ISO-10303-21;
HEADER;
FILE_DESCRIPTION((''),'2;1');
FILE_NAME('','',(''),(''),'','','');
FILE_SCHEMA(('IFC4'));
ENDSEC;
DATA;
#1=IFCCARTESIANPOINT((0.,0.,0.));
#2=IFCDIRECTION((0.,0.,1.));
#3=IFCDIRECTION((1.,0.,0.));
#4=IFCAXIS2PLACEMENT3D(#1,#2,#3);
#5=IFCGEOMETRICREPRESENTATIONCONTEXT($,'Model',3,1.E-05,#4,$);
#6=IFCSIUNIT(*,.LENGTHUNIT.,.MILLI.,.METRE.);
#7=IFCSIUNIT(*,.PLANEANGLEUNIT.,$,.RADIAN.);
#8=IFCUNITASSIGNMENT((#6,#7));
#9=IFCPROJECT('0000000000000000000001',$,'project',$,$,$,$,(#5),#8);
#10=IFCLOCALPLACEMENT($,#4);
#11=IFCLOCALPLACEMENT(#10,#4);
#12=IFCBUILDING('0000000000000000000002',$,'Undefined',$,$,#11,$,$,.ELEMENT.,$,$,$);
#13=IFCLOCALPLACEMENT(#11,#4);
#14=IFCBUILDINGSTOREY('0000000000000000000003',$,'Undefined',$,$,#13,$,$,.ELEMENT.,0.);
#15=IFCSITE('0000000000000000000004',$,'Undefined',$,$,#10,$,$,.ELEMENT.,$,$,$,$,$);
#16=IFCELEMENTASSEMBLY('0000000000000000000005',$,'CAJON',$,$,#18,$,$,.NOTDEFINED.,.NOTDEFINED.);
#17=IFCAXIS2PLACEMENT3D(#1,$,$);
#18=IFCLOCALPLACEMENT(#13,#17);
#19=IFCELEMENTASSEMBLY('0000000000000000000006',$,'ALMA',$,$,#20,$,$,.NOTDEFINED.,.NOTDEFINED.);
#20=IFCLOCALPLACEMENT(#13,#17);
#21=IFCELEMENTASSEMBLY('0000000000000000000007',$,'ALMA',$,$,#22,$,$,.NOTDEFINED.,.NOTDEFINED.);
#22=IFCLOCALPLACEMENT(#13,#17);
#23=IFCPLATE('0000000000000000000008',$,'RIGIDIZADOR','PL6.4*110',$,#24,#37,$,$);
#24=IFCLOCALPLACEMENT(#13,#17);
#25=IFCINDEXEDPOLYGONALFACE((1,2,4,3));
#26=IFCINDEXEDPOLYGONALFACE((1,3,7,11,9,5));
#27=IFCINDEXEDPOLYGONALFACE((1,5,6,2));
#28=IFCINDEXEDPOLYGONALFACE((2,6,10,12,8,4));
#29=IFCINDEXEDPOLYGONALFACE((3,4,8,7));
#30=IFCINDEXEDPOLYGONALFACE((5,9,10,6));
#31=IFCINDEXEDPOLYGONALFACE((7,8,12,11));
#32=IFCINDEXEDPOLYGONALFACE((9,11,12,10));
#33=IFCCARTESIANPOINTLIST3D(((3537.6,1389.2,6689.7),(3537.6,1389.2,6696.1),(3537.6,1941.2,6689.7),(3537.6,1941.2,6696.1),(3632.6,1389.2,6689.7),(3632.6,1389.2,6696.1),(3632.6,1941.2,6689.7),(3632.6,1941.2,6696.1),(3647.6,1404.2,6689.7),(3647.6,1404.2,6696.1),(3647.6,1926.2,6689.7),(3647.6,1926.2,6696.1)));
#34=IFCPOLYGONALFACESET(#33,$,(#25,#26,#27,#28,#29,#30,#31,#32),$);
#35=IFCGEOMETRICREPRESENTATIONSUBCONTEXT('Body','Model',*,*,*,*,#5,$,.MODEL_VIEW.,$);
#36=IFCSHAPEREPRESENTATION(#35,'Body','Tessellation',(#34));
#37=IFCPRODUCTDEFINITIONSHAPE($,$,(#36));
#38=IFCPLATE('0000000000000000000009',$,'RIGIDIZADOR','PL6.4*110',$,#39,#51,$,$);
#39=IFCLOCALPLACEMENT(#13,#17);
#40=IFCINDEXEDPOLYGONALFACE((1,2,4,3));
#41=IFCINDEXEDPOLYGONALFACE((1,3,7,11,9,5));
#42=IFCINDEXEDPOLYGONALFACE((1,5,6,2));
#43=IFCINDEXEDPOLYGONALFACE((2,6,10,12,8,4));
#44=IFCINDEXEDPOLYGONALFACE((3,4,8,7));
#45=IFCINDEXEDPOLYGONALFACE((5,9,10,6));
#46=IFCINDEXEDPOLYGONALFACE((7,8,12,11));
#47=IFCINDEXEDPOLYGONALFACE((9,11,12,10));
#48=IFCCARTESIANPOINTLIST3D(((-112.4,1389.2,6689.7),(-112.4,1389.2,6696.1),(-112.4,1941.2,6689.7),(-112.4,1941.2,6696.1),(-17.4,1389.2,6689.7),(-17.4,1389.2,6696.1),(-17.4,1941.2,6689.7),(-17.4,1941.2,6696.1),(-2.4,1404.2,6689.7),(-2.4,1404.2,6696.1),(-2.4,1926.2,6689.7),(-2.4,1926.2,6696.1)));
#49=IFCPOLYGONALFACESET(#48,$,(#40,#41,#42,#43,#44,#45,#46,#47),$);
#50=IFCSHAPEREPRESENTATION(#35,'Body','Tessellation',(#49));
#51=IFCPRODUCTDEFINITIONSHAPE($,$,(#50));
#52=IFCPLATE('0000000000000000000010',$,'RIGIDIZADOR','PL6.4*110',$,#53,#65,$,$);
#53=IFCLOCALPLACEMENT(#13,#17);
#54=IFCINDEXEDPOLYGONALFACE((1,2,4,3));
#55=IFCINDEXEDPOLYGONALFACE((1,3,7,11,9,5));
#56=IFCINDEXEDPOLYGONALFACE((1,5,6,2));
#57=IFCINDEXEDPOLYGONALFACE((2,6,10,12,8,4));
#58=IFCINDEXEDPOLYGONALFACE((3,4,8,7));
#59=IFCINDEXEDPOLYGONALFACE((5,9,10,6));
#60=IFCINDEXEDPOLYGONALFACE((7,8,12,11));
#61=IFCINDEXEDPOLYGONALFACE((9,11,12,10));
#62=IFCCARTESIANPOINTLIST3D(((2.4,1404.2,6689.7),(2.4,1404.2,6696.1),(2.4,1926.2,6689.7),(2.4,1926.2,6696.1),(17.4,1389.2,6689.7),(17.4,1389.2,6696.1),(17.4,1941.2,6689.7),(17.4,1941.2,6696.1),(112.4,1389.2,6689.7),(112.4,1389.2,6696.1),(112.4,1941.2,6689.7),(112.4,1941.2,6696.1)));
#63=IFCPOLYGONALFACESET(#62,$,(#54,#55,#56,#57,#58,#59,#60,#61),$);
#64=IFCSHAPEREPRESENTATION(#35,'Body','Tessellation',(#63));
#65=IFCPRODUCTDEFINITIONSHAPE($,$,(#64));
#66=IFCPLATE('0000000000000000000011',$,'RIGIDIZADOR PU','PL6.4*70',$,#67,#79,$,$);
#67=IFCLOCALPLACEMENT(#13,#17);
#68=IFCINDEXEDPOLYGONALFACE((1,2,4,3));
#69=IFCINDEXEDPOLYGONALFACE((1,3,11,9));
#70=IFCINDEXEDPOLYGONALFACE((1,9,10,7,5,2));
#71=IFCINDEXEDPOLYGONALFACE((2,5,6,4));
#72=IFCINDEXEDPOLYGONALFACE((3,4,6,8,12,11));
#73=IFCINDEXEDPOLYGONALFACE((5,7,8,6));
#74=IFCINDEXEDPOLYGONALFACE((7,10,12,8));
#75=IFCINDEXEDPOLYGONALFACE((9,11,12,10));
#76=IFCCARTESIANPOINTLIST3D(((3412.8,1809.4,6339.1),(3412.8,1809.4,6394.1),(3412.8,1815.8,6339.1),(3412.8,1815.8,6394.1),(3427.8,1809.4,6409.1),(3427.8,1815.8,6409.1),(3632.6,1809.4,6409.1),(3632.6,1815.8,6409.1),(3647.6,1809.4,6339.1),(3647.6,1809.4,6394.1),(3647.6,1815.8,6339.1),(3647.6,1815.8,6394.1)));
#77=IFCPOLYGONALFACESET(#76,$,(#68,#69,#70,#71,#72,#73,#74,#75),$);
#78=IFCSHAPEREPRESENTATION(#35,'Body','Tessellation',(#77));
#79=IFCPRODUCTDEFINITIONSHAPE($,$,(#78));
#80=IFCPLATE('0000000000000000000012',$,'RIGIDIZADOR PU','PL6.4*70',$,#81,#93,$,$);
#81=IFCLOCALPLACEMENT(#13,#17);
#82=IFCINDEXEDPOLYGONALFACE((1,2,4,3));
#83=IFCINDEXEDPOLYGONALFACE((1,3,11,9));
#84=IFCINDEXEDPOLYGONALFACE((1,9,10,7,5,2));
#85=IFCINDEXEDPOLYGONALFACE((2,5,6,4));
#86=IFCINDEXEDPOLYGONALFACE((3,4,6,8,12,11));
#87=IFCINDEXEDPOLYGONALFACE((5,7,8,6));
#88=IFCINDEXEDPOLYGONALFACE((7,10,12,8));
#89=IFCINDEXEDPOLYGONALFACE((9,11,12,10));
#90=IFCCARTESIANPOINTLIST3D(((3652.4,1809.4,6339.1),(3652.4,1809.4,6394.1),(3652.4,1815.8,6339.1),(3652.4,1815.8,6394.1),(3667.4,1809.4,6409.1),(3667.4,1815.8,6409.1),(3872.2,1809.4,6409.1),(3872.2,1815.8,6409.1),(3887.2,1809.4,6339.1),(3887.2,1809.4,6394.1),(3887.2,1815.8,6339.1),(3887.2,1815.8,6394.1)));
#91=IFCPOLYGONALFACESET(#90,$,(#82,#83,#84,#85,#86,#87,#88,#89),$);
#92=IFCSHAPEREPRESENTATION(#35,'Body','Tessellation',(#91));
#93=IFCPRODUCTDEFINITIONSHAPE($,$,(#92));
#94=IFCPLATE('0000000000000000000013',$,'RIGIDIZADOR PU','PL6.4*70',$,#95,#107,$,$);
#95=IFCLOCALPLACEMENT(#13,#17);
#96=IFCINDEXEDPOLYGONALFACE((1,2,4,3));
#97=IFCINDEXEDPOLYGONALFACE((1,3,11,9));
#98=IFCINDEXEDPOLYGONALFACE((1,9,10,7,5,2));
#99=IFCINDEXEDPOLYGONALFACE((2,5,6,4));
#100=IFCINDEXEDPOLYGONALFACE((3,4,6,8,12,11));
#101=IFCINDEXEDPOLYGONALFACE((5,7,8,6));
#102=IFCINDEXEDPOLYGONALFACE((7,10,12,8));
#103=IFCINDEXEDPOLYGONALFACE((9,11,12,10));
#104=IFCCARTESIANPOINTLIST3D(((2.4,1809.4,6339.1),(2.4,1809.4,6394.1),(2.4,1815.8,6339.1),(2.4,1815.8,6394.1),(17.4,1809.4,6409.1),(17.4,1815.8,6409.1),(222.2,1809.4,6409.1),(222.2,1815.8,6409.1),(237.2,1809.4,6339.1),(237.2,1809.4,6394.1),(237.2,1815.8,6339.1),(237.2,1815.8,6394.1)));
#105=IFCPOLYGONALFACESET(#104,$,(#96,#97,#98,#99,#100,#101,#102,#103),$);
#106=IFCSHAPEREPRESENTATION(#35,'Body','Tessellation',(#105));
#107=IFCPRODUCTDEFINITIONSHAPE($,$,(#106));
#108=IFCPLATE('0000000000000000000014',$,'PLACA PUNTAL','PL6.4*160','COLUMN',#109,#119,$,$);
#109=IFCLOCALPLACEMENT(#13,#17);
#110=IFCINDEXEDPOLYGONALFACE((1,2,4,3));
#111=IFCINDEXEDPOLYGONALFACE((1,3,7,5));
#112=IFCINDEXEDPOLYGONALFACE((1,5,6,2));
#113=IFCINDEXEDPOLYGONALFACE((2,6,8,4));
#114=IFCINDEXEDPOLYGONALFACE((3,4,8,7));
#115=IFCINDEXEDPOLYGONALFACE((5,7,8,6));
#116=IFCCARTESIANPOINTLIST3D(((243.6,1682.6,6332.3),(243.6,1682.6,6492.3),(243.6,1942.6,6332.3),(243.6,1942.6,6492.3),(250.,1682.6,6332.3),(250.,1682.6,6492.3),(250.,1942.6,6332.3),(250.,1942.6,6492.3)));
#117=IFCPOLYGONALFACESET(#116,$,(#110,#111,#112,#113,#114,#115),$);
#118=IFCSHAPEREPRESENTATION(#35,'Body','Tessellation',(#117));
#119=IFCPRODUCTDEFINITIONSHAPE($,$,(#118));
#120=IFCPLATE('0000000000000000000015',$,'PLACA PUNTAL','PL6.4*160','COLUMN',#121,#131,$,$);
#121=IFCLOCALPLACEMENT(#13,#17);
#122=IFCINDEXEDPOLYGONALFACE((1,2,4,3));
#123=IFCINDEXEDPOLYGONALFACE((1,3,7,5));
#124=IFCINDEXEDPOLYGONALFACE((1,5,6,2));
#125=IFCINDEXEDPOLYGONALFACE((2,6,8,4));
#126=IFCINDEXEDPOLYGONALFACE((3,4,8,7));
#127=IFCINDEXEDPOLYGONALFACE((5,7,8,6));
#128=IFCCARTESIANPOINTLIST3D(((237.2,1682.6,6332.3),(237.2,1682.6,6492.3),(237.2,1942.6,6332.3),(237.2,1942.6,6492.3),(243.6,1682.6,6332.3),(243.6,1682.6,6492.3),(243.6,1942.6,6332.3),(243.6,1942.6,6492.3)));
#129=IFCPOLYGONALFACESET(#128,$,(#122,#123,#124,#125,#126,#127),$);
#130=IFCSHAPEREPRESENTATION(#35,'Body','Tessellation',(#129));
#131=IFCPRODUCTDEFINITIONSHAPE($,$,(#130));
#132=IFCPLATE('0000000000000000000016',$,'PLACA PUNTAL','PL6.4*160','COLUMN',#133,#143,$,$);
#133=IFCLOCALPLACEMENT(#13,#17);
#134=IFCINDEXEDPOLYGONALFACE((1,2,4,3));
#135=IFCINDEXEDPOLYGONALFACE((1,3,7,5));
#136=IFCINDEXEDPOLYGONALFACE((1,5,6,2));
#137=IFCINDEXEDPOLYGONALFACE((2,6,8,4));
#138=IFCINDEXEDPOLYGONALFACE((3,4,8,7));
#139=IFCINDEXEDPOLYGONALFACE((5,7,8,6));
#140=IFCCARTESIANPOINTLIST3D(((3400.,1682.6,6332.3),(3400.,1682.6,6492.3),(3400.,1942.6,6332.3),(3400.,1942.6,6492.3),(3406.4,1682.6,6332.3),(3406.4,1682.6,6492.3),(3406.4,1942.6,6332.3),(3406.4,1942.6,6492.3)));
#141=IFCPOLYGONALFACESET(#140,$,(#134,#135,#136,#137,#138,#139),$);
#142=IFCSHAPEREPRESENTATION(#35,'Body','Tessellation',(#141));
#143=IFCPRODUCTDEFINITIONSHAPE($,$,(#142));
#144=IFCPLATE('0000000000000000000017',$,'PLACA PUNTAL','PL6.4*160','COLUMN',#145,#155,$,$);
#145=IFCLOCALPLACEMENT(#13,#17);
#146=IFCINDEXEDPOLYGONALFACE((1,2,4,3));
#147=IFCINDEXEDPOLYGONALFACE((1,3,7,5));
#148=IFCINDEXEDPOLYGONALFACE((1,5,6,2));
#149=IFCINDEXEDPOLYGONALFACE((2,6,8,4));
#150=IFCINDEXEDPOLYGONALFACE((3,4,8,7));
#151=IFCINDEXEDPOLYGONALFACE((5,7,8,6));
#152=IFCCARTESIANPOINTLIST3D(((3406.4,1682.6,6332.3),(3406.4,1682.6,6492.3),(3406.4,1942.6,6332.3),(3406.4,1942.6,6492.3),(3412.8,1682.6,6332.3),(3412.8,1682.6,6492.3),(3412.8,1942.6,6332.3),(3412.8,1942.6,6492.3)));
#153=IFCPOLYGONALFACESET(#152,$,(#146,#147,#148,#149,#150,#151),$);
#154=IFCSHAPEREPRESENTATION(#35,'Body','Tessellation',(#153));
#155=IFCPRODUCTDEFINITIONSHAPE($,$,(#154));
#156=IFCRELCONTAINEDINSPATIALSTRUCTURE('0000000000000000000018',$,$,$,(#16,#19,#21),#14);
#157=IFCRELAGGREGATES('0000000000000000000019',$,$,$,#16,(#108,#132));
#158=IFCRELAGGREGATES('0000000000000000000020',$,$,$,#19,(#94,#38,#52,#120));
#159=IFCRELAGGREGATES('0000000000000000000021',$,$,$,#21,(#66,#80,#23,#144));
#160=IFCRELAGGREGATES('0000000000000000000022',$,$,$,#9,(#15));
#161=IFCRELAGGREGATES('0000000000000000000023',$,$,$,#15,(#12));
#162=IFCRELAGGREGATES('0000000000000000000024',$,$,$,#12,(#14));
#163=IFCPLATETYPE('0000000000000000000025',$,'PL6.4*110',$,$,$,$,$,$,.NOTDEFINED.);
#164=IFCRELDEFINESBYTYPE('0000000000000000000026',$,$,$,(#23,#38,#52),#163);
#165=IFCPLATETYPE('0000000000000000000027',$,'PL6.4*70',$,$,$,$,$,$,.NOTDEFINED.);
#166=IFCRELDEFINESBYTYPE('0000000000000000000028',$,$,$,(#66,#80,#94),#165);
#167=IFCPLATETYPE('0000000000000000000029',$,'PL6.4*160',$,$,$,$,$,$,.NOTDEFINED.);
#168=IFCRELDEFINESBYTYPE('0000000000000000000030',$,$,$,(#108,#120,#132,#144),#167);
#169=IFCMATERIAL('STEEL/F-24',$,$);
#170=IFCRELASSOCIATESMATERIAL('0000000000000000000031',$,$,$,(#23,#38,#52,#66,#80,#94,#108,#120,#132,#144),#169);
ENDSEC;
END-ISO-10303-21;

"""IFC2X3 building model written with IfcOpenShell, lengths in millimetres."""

from ifc_helpers import new_model, si_unit, frame, origin_with_axes, place, context, subcontext, project, spatial, polyline, outline, extrude, material, type_object, element, aggregate, save


model = new_model("IFC2X3")

# Units and contexts
model_context = context("Model", 3, precision=1e-05, world=origin_with_axes())
body_context = subcontext(model_context, "Body", "Model", "MODEL_VIEW")
ifc_project = project(units=[si_unit("LENGTHUNIT", "METRE", prefix="MILLI"), si_unit("PLANEANGLEUNIT", "RADIAN")], contexts=[model_context])

# Site, building, storey
site_placement = place(None, origin_with_axes())
site = spatial("IfcSite", under=ifc_project, at=site_placement, Name="Undefined", CompositionType="ELEMENT")
building_placement = place(site_placement, origin_with_axes())
building = spatial("IfcBuilding", under=site, at=building_placement, Name="Undefined", CompositionType="ELEMENT")
storey_placement = place(building_placement, origin_with_axes())
storey = spatial("IfcBuildingStorey", under=building, at=storey_placement, Name="Undefined", CompositionType="ELEMENT", Elevation=0.0)

# Element assembly
assembly_1_placement = place(storey_placement, origin_with_axes())
assembly_1 = element("IfcElementAssembly", 1, at=assembly_1_placement, inside=storey, Name="CAJON", AssemblyPlace="NOTDEFINED", PredefinedType="NOTDEFINED")
ifc_material_1 = material(Name="STEEL/F-24")

# Element assembly
assembly_2_placement = place(storey_placement, origin_with_axes())
assembly_2 = element("IfcElementAssembly", 2, at=assembly_2_placement, inside=storey, Name="ALMA", AssemblyPlace="NOTDEFINED", PredefinedType="NOTDEFINED")

# Element assembly, plate
assembly_3_placement = place(storey_placement, origin_with_axes())
assembly_3 = element("IfcElementAssembly", 3, at=assembly_3_placement, inside=storey, Name="ALMA", AssemblyPlace="NOTDEFINED", PredefinedType="NOTDEFINED")
plate_type_1 = type_object("IfcPlateType", Name="PL6.4*110", PredefinedType="NOTDEFINED")
plate_1_placement = place(assembly_3_placement, frame((3537.6, 1941.2, 6692.9), z_axis=(0.0, 0.0, -1.0), x_axis=(1.0, 0.0, 0.0)))
plate_1 = element("IfcPlate", 4, at=plate_1_placement, type_object=plate_type_1, material=ifc_material_1, Name="RIGIDIZADOR", Description="PL6.4*110", context=body_context, shape_type="SweptSolid", body=[
    extrude(outline(polyline([(0.0, 0.0), (95.0, 0.0), (110.0, 15.0), (110.0, 537.0), (95.0, 552.0), (0.0, 552.0), (0.0, 0.0)])), frame((0.0, 0.0, -3.2), z_axis=(0.0, 0.0, 1.0), x_axis=(1.0, 0.0, 0.0)), (0.0, 0.0, 1.0), 6.4),
])

# Plates
plate_2_placement = place(assembly_2_placement, frame((-112.4, 1941.2, 6692.9), z_axis=(0.0, 0.0, -1.0), x_axis=(1.0, 0.0, 0.0)))
plate_2 = element("IfcPlate", 5, at=plate_2_placement, type_object=plate_type_1, material=ifc_material_1, Name="RIGIDIZADOR", Description="PL6.4*110", context=body_context, shape_type="SweptSolid", body=[
    extrude(outline(polyline([(0.0, 0.0), (95.0, 0.0), (110.0, 15.0), (110.0, 537.0), (95.0, 552.0), (0.0, 552.0), (0.0, 0.0)])), frame((0.0, 0.0, -3.2), z_axis=(0.0, 0.0, 1.0), x_axis=(1.0, 0.0, 0.0)), (0.0, 0.0, 1.0), 6.4),
])
plate_3_placement = place(assembly_2_placement, frame((112.4, 1941.2, 6692.9), z_axis=(0.0, 0.0, 1.0), x_axis=(-1.0, 0.0, 0.0)))
plate_3 = element("IfcPlate", 6, at=plate_3_placement, type_object=plate_type_1, material=ifc_material_1, Name="RIGIDIZADOR", Description="PL6.4*110", context=body_context, shape_type="SweptSolid", body=[
    extrude(outline(polyline([(0.0, 0.0), (95.0, 0.0), (110.0, 15.0), (110.0, 537.0), (95.0, 552.0), (0.0, 552.0), (0.0, 0.0)])), frame((0.0, 0.0, -3.2), z_axis=(0.0, 0.0, 1.0), x_axis=(1.0, 0.0, 0.0)), (0.0, 0.0, 1.0), 6.4),
])
plate_type_2 = type_object("IfcPlateType", Name="PL6.4*70", PredefinedType="NOTDEFINED")
plate_4_placement = place(assembly_3_placement, frame((3647.6, 1812.6, 6409.1), z_axis=(-0.000003, -1.0, 0.0), x_axis=(-1.0, 0.000003, 0.0)))
plate_4 = element("IfcPlate", 7, at=plate_4_placement, type_object=plate_type_2, material=ifc_material_1, Name="RIGIDIZADOR PU", Description="PL6.4*70", context=body_context, shape_type="SweptSolid", body=[
    extrude(outline(polyline([(0.0, 15.0), (15.0, 0.0), (219.8, 0.0), (234.8, 15.0), (234.8, 70.0), (0.0, 70.0), (0.0, 15.0)])), frame((0.0, 0.0, -3.2), z_axis=(0.0, 0.0, 1.0), x_axis=(1.0, 0.0, 0.0)), (0.0, 0.0, 1.0), 6.4),
])
plate_5_placement = place(assembly_3_placement, frame((3652.4, 1812.6, 6409.1), z_axis=(0.000003, 1.0, 0.0), x_axis=(1.0, -0.000003, 0.0)))
plate_5 = element("IfcPlate", 8, at=plate_5_placement, type_object=plate_type_2, material=ifc_material_1, Name="RIGIDIZADOR PU", Description="PL6.4*70", context=body_context, shape_type="SweptSolid", body=[
    extrude(outline(polyline([(0.0, 15.0), (15.0, 0.0), (219.8, 0.0), (234.8, 15.0), (234.8, 70.0), (0.0, 70.0), (0.0, 15.0)])), frame((0.0, 0.0, -3.2), z_axis=(0.0, 0.0, 1.0), x_axis=(1.0, 0.0, 0.0)), (0.0, 0.0, 1.0), 6.4),
])
plate_6_placement = place(assembly_2_placement, frame((2.4, 1812.6, 6409.1), z_axis=(0.000003, 1.0, 0.0), x_axis=(1.0, -0.000003, 0.0)))
plate_6 = element("IfcPlate", 9, at=plate_6_placement, type_object=plate_type_2, material=ifc_material_1, Name="RIGIDIZADOR PU", Description="PL6.4*70", context=body_context, shape_type="SweptSolid", body=[
    extrude(outline(polyline([(0.0, 15.0), (15.0, 0.0), (219.8, 0.0), (234.8, 15.0), (234.8, 70.0), (0.0, 70.0), (0.0, 15.0)])), frame((0.0, 0.0, -3.2), z_axis=(0.0, 0.0, 1.0), x_axis=(1.0, 0.0, 0.0)), (0.0, 0.0, 1.0), 6.4),
])
plate_type_3 = type_object("IfcPlateType", Name="PL6.4*160", PredefinedType="NOTDEFINED")
plate_7_placement = place(assembly_1_placement, frame((246.8, 1942.6, 6412.3), z_axis=(-1.0, 0.0, 0.0), x_axis=(0.0, -1.0, 0.0)))
plate_7 = element("IfcPlate", 10, at=plate_7_placement, type_object=plate_type_3, material=ifc_material_1, Name="PLACA PUNTAL", Description="PL6.4*160", ObjectType="COLUMN", context=body_context, shape_type="SweptSolid", body=[
    extrude(outline(polyline([(0.0, -80.0), (0.0, 80.0), (260.0, 80.0), (260.0, -80.0), (0.0, -80.0)])), frame((0.0, 0.0, -3.2), z_axis=(0.0, 0.0, 1.0), x_axis=(1.0, 0.0, 0.0)), (0.0, 0.0, 1.0), 6.4),
])
plate_8_placement = place(assembly_2_placement, frame((240.4, 1942.6, 6412.3), z_axis=(-1.0, 0.0, 0.0), x_axis=(0.0, -1.0, 0.0)))
plate_8 = element("IfcPlate", 11, at=plate_8_placement, type_object=plate_type_3, material=ifc_material_1, Name="PLACA PUNTAL", Description="PL6.4*160", ObjectType="COLUMN", context=body_context, shape_type="SweptSolid", body=[
    extrude(outline(polyline([(0.0, -80.0), (0.0, 80.0), (260.0, 80.0), (260.0, -80.0), (0.0, -80.0)])), frame((0.0, 0.0, -3.2), z_axis=(0.0, 0.0, 1.0), x_axis=(1.0, 0.0, 0.0)), (0.0, 0.0, 1.0), 6.4),
])
plate_9_placement = place(assembly_1_placement, frame((3403.2, 1942.6, 6412.3), z_axis=(-1.0, 0.0, 0.0), x_axis=(0.0, -1.0, 0.0)))
plate_9 = element("IfcPlate", 12, at=plate_9_placement, type_object=plate_type_3, material=ifc_material_1, Name="PLACA PUNTAL", Description="PL6.4*160", ObjectType="COLUMN", context=body_context, shape_type="SweptSolid", body=[
    extrude(outline(polyline([(0.0, -80.0), (0.0, 80.0), (260.0, 80.0), (260.0, -80.0), (0.0, -80.0)])), frame((0.0, 0.0, -3.2), z_axis=(0.0, 0.0, 1.0), x_axis=(1.0, 0.0, 0.0)), (0.0, 0.0, 1.0), 6.4),
])
aggregate(assembly_1, [plate_7, plate_9])
plate_10_placement = place(assembly_3_placement, frame((3409.6, 1942.6, 6412.3), z_axis=(-1.0, 0.0, 0.0), x_axis=(0.0, -1.0, 0.0)))
plate_10 = element("IfcPlate", 13, at=plate_10_placement, type_object=plate_type_3, material=ifc_material_1, Name="PLACA PUNTAL", Description="PL6.4*160", ObjectType="COLUMN", context=body_context, shape_type="SweptSolid", body=[
    extrude(outline(polyline([(0.0, -80.0), (0.0, 80.0), (260.0, 80.0), (260.0, -80.0), (0.0, -80.0)])), frame((0.0, 0.0, -3.2), z_axis=(0.0, 0.0, 1.0), x_axis=(1.0, 0.0, 0.0)), (0.0, 0.0, 1.0), 6.4),
])

aggregate(assembly_2, [plate_6, plate_2, plate_3, plate_8])
aggregate(assembly_3, [plate_4, plate_5, plate_1, plate_10])

save(model, "model.ifc")
